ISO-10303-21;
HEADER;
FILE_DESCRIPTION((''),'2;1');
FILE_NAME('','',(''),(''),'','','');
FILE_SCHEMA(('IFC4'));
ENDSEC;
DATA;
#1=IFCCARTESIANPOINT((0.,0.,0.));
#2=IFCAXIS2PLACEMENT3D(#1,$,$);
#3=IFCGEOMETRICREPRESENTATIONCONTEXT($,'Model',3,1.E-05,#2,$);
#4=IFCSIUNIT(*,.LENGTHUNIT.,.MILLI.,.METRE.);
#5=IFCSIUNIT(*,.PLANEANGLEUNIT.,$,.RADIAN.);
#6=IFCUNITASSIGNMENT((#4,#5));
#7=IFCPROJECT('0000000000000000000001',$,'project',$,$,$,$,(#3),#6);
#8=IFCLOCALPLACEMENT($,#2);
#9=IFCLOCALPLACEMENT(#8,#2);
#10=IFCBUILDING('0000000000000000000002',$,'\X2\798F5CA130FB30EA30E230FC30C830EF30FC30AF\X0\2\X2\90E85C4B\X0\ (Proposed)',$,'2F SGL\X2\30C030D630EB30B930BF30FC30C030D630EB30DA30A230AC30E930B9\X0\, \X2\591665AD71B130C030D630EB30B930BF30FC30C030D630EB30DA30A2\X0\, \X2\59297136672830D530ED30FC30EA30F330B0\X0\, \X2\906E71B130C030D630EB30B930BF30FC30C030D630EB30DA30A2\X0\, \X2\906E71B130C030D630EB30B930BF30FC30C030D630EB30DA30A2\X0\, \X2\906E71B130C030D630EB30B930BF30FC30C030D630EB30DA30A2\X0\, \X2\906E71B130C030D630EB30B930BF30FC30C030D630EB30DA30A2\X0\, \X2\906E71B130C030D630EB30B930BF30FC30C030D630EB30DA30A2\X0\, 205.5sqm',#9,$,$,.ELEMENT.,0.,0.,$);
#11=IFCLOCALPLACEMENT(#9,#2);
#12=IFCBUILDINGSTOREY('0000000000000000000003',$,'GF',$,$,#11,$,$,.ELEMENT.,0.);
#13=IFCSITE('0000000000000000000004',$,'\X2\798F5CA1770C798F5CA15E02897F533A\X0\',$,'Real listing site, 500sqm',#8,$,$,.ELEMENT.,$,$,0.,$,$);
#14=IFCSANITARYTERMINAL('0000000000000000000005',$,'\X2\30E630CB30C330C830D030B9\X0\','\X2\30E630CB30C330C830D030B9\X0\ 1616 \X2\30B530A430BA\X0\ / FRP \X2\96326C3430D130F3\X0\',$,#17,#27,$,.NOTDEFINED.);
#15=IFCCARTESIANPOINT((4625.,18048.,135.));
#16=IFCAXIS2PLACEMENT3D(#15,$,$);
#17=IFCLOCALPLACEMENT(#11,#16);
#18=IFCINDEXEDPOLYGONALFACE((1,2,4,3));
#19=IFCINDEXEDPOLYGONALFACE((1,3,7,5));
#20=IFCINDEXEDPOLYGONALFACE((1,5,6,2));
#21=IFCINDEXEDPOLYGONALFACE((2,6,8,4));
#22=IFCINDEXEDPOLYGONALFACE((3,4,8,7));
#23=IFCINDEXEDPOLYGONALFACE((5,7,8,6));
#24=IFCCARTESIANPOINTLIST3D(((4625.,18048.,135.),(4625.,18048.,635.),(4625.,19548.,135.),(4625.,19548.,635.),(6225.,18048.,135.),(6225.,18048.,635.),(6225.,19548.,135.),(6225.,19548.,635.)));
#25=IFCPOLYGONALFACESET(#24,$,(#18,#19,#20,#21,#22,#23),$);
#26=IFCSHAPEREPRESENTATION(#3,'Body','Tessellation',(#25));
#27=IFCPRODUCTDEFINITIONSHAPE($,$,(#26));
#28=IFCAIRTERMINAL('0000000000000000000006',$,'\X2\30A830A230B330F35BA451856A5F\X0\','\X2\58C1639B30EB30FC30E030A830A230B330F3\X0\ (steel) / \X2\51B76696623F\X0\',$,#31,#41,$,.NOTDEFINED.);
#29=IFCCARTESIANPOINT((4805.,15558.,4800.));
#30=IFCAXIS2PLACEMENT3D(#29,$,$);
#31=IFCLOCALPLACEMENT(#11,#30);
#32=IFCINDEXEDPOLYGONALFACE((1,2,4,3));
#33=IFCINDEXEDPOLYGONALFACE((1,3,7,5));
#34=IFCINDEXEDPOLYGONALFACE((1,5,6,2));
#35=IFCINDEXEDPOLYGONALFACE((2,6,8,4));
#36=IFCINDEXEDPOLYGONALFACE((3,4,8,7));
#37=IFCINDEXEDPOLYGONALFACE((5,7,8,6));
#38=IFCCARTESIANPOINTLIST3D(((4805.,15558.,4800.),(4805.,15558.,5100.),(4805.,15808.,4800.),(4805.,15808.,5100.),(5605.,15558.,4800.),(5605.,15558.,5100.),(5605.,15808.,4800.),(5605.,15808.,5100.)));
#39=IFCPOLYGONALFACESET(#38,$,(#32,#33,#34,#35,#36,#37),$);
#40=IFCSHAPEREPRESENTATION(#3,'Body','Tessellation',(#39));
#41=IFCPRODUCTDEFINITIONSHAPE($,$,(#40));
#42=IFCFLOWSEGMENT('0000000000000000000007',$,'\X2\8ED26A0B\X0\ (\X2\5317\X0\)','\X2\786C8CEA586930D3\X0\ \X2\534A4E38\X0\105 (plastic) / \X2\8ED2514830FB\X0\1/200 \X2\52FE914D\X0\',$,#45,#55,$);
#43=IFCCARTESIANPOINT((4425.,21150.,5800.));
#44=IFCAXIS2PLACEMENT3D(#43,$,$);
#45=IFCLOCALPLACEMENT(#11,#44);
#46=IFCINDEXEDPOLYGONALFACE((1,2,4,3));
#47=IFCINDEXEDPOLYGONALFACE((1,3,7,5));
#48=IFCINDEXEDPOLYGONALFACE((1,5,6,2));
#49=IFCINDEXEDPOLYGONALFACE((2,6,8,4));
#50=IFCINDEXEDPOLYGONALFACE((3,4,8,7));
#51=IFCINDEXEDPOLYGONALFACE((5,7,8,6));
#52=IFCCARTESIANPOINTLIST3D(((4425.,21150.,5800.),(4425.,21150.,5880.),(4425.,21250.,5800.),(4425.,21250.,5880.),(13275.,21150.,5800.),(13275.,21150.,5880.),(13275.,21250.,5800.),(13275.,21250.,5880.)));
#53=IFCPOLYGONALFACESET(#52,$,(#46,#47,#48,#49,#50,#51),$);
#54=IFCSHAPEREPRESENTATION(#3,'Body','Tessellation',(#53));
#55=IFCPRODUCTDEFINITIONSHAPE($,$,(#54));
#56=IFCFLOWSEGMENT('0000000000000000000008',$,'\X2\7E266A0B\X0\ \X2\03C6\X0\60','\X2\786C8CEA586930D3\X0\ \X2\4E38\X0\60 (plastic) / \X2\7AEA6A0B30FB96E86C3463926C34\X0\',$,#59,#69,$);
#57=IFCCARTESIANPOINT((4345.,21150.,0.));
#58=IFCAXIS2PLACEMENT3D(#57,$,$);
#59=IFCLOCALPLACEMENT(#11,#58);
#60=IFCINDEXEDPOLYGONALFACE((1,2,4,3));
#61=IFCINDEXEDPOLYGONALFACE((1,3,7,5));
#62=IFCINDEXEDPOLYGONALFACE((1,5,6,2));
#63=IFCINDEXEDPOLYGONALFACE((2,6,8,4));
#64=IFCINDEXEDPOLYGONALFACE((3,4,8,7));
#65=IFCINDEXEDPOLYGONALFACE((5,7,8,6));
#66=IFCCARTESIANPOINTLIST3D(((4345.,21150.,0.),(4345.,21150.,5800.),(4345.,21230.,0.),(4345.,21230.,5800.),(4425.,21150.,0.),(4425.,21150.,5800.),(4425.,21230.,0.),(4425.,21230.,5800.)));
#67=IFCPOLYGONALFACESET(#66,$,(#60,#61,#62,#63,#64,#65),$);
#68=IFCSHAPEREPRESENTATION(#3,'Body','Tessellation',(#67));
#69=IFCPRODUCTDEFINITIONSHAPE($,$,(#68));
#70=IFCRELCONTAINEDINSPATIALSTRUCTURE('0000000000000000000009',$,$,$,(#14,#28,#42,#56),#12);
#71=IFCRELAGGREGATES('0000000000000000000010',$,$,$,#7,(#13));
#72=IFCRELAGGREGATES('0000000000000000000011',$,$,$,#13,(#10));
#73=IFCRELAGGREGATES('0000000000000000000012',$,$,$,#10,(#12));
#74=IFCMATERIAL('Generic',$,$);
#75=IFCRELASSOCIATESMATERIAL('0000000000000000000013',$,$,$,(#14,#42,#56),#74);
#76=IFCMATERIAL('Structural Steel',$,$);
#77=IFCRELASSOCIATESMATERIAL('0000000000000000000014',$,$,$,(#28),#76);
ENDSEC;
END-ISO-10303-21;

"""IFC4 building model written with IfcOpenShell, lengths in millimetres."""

from ifc_helpers import new_model, si_unit, frame, frame_2d, origin, place, context, project, spatial, rectangle, extrude, material, element, save


model = new_model("IFC4")

# Units and contexts
model_context = context("Model", 3, precision=1e-05, world=origin())
ifc_project = project(units=[si_unit("LENGTHUNIT", "METRE", prefix="MILLI"), si_unit("PLANEANGLEUNIT", "RADIAN")], contexts=[model_context])

# Site, building, storey
site_placement = place(None, origin())
site = spatial("IfcSite", under=ifc_project, at=site_placement, Name="福岡県福岡市西区", ObjectType="Real listing site, 500sqm", CompositionType="ELEMENT", RefElevation=0.0)
building_placement = place(site_placement, origin())
building = spatial("IfcBuilding", under=site, at=building_placement, Name="福岡・リモートワーク2部屋 (Proposed)", ObjectType="2F SGLダブルスターダブルペアガラス, 外断熱ダブルスターダブルペア, 天然木フローリング, 遮熱ダブルスターダブルペア, 遮熱ダブルスターダブルペア, 遮熱ダブルスターダブルペア, 遮熱ダブルスターダブルペア, 遮熱ダブルスターダブルペア, 205.5sqm", CompositionType="ELEMENT", ElevationOfRefHeight=0.0, ElevationOfTerrain=0.0)
storey_placement = place(building_placement, origin())
storey = spatial("IfcBuildingStorey", under=building, at=storey_placement, Name="GF", CompositionType="ELEMENT", Elevation=0.0)

# Shared definitions
ifc_material_1 = material(Name="Generic")

# Sanitary terminal
sanitary_terminal_placement = place(storey_placement, frame((4625.0, 18048.0, 135.0)))
element("IfcSanitaryTerminal", 1, at=sanitary_terminal_placement, inside=storey, material=ifc_material_1, Name="ユニットバス", Description="ユニットバス 1616 サイズ / FRP 防水パン", PredefinedType="NOTDEFINED", context=model_context, shape_type="SweptSolid", body=[
    extrude(rectangle(XDim=1600.0, YDim=1500.0, at=frame_2d((800.0, 750.0))), frame((4625.0, 18048.0, 135.0)), (0.0, 0.0, 1.0), 500.0),
])

# Air terminal
ifc_material_2 = material(Name="Structural Steel")
air_terminal_placement = place(storey_placement, frame((4805.0, 15558.0, 4800.0)))
element("IfcAirTerminal", 2, at=air_terminal_placement, inside=storey, material=ifc_material_2, Name="エアコン室内機", Description="壁掛ルームエアコン (steel) / 冷暖房", PredefinedType="NOTDEFINED", context=model_context, shape_type="SweptSolid", body=[
    extrude(rectangle(XDim=800.0, YDim=250.0, at=frame_2d((400.0, 125.0))), frame((4805.0, 15558.0, 4800.0)), (0.0, 0.0, 1.0), 300.0),
])

# Flow segments
flow_segment_1_placement = place(storey_placement, frame((4425.0, 21150.0, 5800.0)))
element("IfcFlowSegment", 3, at=flow_segment_1_placement, inside=storey, material=ifc_material_1, Name="軒樋 (北)", Description="硬質塩ビ 半丸105 (plastic) / 軒先・1/200 勾配", context=model_context, shape_type="SweptSolid", body=[
    extrude(rectangle(XDim=8850.0, YDim=100.0, at=frame_2d((4425.0, 50.0))), frame((4425.0, 21150.0, 5800.0)), (0.0, 0.0, 1.0), 80.0),
])
flow_segment_2_placement = place(storey_placement, frame((4345.0, 21150.0, 0.0)))
element("IfcFlowSegment", 4, at=flow_segment_2_placement, inside=storey, material=ifc_material_1, Name="縦樋 φ60", Description="硬質塩ビ 丸60 (plastic) / 竪樋・雨水排水", context=model_context, shape_type="SweptSolid", body=[
    extrude(rectangle(XDim=80.0, YDim=80.0, at=frame_2d((40.0, 40.0))), frame((4345.0, 21150.0, 0.0)), (0.0, 0.0, 1.0), 5800.0),
])

save(model, "model.ifc")
